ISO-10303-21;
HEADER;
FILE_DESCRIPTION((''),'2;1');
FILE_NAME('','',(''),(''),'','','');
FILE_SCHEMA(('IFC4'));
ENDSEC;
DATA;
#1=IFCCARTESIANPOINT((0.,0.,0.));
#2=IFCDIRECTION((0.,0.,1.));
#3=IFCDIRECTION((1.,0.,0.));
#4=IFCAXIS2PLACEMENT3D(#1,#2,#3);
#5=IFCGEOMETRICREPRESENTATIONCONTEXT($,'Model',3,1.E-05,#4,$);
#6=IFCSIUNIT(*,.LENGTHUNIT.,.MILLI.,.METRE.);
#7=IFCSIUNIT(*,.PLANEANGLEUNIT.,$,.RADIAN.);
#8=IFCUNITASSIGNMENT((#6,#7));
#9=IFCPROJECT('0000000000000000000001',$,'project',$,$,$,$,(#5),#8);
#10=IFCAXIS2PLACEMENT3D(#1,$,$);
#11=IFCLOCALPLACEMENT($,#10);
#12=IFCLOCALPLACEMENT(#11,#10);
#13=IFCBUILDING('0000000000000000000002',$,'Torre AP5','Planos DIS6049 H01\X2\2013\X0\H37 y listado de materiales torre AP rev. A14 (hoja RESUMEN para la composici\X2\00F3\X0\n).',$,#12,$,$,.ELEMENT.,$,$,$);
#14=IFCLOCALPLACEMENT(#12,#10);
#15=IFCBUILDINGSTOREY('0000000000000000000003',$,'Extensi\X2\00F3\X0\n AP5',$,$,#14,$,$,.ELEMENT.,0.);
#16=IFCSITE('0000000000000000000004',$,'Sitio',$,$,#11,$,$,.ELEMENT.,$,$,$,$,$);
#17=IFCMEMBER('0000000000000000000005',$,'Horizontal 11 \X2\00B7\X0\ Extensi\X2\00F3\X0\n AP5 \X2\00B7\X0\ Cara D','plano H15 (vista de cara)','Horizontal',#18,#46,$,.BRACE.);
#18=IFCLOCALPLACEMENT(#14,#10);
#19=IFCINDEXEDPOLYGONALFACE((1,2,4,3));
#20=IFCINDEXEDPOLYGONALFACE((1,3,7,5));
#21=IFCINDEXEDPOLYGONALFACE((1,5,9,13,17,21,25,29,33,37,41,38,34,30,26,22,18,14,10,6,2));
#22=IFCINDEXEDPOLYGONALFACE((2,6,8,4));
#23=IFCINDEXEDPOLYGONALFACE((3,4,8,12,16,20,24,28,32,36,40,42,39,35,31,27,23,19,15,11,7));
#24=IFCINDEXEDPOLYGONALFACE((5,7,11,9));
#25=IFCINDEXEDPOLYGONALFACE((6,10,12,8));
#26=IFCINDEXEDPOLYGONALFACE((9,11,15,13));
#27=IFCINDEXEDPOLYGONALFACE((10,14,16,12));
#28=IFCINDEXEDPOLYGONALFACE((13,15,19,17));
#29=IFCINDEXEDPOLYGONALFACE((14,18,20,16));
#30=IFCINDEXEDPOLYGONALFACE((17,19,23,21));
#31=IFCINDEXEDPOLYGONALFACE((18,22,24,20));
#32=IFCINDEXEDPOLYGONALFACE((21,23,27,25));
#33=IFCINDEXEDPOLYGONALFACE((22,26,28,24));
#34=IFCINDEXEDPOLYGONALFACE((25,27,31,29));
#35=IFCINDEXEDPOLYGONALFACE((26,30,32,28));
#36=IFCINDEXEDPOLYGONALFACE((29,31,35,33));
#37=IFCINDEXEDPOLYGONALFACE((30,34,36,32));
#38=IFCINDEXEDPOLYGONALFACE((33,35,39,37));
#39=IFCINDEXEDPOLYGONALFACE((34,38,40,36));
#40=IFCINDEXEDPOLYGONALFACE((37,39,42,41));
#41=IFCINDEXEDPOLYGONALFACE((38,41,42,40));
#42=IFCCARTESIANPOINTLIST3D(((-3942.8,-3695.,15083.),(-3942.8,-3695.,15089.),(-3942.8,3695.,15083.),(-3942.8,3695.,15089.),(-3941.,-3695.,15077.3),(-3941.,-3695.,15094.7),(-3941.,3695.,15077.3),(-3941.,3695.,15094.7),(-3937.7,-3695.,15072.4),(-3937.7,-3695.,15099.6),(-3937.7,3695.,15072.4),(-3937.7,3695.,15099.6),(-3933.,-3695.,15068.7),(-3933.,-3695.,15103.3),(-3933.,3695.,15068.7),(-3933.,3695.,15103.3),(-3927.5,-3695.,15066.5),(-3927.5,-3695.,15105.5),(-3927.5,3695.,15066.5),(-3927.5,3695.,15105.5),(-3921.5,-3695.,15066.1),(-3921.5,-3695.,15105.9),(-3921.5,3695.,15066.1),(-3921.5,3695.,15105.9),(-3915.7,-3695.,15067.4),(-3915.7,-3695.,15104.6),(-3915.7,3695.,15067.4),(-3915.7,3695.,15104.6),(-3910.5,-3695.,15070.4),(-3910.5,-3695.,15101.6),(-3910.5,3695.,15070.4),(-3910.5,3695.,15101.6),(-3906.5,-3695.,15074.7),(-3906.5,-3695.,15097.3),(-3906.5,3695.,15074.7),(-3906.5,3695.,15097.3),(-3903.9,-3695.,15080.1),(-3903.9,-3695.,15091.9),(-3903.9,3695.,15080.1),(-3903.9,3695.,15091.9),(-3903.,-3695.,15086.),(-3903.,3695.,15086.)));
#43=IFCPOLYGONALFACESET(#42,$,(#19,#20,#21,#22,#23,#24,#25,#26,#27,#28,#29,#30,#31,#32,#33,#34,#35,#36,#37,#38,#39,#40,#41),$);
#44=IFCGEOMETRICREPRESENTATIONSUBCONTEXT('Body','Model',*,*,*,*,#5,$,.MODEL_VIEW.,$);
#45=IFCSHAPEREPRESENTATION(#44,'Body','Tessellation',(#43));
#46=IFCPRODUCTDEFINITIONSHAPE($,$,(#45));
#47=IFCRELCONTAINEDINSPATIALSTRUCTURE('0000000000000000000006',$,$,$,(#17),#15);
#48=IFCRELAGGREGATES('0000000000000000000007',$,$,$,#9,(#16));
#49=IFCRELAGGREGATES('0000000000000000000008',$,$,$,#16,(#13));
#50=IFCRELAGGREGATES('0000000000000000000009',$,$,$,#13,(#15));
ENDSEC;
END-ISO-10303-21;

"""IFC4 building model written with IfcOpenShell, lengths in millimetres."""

from ifc_helpers import new_model, si_unit, frame, origin, origin_with_axes, place, context, subcontext, project, spatial, circle, extrude, element, save


model = new_model("IFC4")

# Units and contexts
model_context = context("Model", 3, precision=1e-05, world=origin_with_axes())
body_context = subcontext(model_context, "Body", "Model", "MODEL_VIEW")
ifc_project = project(units=[si_unit("LENGTHUNIT", "METRE", prefix="MILLI"), si_unit("PLANEANGLEUNIT", "RADIAN")], contexts=[model_context])

# Site, building, storey
site_placement = place(None, origin())
site = spatial("IfcSite", under=ifc_project, at=site_placement, Name="Sitio", CompositionType="ELEMENT")
building_placement = place(site_placement, origin())
building = spatial("IfcBuilding", under=site, at=building_placement, Name="Torre AP5", Description="Planos DIS6049 H01–H37 y listado de materiales torre AP rev. A14 (hoja RESUMEN para la composición).", CompositionType="ELEMENT")
storey_placement = place(building_placement, origin())
storey = spatial("IfcBuildingStorey", under=building, at=storey_placement, Name="Extensión AP5", CompositionType="ELEMENT", Elevation=0.0)

# Member
for number, where, z_axis, x_axis, name in (
    (1, (-3923.0, -3695.0, 15086.0), (0.0, 1.0, 0.0), (1.0, 0.0, 0.0), "Horizontal 11 · Extensión AP5 · Cara D"),
):
    element("IfcMember", number, at=place(storey_placement, frame(where, z_axis=z_axis, x_axis=x_axis)), inside=storey, Name=name, Description="plano H15 (vista de cara)", ObjectType="Horizontal", PredefinedType="BRACE", context=body_context, shape_type="SweptSolid", body=[
        extrude(circle(Radius=20.0), None, (0.0, 0.0, 1.0), 7390.0),
    ])

save(model, "model.ifc")
